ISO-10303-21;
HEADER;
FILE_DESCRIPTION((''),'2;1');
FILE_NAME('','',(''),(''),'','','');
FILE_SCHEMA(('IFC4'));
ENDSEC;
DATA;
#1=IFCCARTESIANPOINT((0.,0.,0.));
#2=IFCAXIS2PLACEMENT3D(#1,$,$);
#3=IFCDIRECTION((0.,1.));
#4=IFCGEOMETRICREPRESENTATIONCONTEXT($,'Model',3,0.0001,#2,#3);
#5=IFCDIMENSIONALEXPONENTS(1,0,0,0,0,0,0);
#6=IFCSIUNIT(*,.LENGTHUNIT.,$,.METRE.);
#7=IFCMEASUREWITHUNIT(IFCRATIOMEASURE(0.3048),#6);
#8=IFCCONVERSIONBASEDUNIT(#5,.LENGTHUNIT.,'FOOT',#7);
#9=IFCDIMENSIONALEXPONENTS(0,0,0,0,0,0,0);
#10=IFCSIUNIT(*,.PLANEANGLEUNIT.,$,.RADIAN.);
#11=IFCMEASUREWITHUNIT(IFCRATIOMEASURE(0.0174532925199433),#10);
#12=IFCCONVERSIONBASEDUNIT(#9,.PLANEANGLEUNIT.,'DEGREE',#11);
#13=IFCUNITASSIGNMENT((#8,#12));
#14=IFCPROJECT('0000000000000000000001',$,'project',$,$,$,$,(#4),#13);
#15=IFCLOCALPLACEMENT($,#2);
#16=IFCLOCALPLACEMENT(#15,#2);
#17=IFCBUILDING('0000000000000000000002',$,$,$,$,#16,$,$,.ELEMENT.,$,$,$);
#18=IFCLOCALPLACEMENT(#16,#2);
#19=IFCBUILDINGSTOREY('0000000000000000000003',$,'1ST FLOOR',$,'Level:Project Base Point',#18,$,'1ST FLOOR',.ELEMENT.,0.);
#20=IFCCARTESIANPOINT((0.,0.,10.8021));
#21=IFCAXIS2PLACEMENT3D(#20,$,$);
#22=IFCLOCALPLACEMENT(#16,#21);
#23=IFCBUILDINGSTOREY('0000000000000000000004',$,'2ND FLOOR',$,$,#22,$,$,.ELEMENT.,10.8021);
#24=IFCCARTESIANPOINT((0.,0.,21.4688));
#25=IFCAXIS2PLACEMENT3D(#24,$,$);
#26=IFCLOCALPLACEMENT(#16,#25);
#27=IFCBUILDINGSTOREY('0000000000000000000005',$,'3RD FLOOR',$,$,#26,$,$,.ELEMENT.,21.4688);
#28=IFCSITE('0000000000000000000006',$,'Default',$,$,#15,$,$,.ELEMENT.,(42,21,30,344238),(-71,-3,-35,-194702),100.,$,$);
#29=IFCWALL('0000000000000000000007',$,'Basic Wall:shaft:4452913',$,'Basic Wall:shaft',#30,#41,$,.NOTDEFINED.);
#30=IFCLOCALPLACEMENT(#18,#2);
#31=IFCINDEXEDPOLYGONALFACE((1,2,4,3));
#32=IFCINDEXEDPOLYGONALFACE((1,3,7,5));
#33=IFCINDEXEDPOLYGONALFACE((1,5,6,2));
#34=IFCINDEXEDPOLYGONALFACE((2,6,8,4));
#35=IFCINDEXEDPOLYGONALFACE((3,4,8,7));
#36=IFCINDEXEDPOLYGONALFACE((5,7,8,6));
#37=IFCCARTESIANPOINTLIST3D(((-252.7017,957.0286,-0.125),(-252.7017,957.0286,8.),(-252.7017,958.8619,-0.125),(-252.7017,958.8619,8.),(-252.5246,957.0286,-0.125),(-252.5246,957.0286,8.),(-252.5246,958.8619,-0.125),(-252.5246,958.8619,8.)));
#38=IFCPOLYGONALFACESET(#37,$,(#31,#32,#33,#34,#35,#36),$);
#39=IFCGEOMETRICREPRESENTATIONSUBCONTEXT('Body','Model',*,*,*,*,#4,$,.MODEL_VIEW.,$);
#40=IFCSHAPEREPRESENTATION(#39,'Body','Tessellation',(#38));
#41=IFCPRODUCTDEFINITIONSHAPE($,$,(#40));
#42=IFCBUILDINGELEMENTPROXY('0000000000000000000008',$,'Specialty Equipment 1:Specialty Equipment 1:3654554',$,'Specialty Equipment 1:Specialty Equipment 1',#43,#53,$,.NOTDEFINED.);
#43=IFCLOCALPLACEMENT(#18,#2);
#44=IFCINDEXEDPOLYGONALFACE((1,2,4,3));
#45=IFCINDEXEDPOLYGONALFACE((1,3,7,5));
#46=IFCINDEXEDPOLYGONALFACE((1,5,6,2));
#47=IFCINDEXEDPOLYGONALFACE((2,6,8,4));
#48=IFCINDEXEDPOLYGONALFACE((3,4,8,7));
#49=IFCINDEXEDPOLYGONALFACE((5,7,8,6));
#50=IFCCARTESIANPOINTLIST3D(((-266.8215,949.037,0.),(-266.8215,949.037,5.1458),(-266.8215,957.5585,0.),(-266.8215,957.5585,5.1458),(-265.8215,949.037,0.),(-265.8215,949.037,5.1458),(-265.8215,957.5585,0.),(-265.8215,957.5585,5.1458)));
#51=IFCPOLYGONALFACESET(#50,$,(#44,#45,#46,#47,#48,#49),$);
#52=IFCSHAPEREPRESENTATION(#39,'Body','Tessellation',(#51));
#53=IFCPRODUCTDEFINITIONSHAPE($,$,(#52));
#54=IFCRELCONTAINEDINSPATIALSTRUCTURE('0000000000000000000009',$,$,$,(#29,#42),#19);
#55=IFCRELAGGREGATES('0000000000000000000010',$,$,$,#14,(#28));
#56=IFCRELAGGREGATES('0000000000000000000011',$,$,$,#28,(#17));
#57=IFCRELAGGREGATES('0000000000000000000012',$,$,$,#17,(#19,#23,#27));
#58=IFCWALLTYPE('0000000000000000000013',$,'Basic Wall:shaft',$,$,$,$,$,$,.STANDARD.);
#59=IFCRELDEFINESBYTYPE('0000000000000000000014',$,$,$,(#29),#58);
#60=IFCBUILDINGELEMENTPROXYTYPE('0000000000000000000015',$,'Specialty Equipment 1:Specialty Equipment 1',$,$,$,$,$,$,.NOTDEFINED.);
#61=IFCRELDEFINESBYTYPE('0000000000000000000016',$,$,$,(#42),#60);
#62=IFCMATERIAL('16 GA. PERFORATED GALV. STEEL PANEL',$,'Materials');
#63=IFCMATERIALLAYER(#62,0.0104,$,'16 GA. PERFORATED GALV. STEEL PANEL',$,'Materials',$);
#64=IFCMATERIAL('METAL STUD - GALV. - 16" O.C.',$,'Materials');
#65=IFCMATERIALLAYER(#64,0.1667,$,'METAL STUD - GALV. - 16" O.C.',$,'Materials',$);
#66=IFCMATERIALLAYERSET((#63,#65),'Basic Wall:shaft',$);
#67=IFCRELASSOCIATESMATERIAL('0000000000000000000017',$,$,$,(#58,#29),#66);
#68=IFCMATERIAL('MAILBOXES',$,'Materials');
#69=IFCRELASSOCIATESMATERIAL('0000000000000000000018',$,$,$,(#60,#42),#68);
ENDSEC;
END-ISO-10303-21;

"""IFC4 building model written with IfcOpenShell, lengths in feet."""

from ifc_helpers import new_model, entity, si_unit, converted_unit, direction, frame, frame_2d, origin, place, context, subcontext, project, spatial, rectangle, extrude, source, transform, mapped, material, layer, layer_set, layer_usage, type_object, type_shapes, element, save


model = new_model("IFC4")

# Units and contexts
model_context = context("Model", 3, precision=0.0001, world=origin(), true_north=direction((0.0, 1.0)))
body_context = subcontext(model_context, "Body", "Model", "MODEL_VIEW")
ifc_project = project(units=[converted_unit("LENGTHUNIT", "FOOT", entity("IfcRatioMeasure", 0.3048), si_unit("LENGTHUNIT", "METRE"), dimensions=[1, 0, 0, 0, 0, 0, 0]), converted_unit("PLANEANGLEUNIT", "DEGREE", entity("IfcRatioMeasure", 0.0174532925199433), si_unit("PLANEANGLEUNIT", "RADIAN"), dimensions=[0, 0, 0, 0, 0, 0, 0])], contexts=[model_context])

# Site, building, storey
site_placement = place(None, origin())
site = spatial("IfcSite", under=ifc_project, at=site_placement, Name="Default", CompositionType="ELEMENT", RefLatitude=(42, 21, 30, 344238), RefLongitude=(-71, -3, -35, -194702), RefElevation=100.0)
building_placement = place(site_placement, origin())
building = spatial("IfcBuilding", under=site, at=building_placement, CompositionType="ELEMENT")
storey_1_placement = place(building_placement, origin())
storey_1 = spatial("IfcBuildingStorey", under=building, at=storey_1_placement, Name="1ST FLOOR", ObjectType="Level:Project Base Point", LongName="1ST FLOOR", CompositionType="ELEMENT", Elevation=0.0)

# Shared definitions
storey_2_placement = place(building_placement, frame((0.0, 0.0, 21.4688)))
storey_3_placement = place(building_placement, frame((0.0, 0.0, 10.8021)))

# Shared definitions
storey_3 = spatial("IfcBuildingStorey", under=building, at=storey_3_placement, Name="2ND FLOOR", CompositionType="ELEMENT", Elevation=10.8021)

# Shared definitions
storey_2 = spatial("IfcBuildingStorey", under=building, at=storey_2_placement, Name="3RD FLOOR", CompositionType="ELEMENT", Elevation=21.4688)

# Wall
ifc_material_1 = material(Name="16 GA. PERFORATED GALV. STEEL PANEL", Category="Materials")
ifc_layer_1 = layer(ifc_material_1, 0.0104, Name="16 GA. PERFORATED GALV. STEEL PANEL", Category="Materials")
ifc_material_2 = material(Name="METAL STUD - GALV. - 16\" O.C.", Category="Materials")
ifc_layer_2 = layer(ifc_material_2, 0.1667, Name="METAL STUD - GALV. - 16\" O.C.", Category="Materials")
ifc_layer_set_1 = layer_set([ifc_layer_1, ifc_layer_2], Name="Basic Wall:shaft")
ifc_layer_usage_1 = layer_usage(ifc_layer_set_1, "AXIS2", "POSITIVE", -0.0885)
wall_type_1 = type_object("IfcWallType", Name="Basic Wall:shaft", PredefinedType="STANDARD", material=ifc_layer_set_1)
wall_1_placement = place(storey_1_placement, frame((-252.6132, 957.0286, -0.125), z_axis=(0.0, 0.0, 1.0), x_axis=(0.0, 1.0, 0.0)))
element("IfcWall", 1, at=wall_1_placement, inside=storey_1, type_object=wall_type_1, material=ifc_layer_usage_1, Name="Basic Wall:shaft:4452913", ObjectType="Basic Wall:shaft", PredefinedType="NOTDEFINED", context=body_context, shape_type="SweptSolid", body=[
    extrude(rectangle(XDim=1.8333, YDim=0.1771, at=frame_2d((0.9167, 0.0), x_axis=(-1.0, 0.0))), origin(), (0.0, 0.0, 1.0), 8.125),
])

# Building element proxy
ifc_material_3 = material(Name="MAILBOXES", Category="Materials")
building_element_proxy_type_1 = type_object("IfcBuildingElementProxyType", Name="Specialty Equipment 1:Specialty Equipment 1", PredefinedType="NOTDEFINED", material=ifc_material_3)
shared_shape_1 = source(origin(), body_context, "Body", "SweptSolid", [
    extrude(rectangle(XDim=1.0, YDim=8.5215, at=frame_2d((0.0, 0.0), x_axis=(1.0, 0.0))), frame((0.5, 4.2607, 0.0)), (0.0, 0.0, 1.0), 5.1458),
])
type_shapes(building_element_proxy_type_1, [shared_shape_1])
proxy_1_placement = place(storey_1_placement, frame((-266.8215, 949.037, 0.0)))
element("IfcBuildingElementProxy", 2, at=proxy_1_placement, inside=storey_1, type_object=building_element_proxy_type_1, material=ifc_material_3, Name="Specialty Equipment 1:Specialty Equipment 1:3654554", ObjectType="Specialty Equipment 1:Specialty Equipment 1", PredefinedType="NOTDEFINED", context=body_context, shape_type="MappedRepresentation", body=[
    mapped(shared_shape_1, transform((0.0, 0.0, 0.0), scale=1.0)),
])

save(model, "model.ifc")
